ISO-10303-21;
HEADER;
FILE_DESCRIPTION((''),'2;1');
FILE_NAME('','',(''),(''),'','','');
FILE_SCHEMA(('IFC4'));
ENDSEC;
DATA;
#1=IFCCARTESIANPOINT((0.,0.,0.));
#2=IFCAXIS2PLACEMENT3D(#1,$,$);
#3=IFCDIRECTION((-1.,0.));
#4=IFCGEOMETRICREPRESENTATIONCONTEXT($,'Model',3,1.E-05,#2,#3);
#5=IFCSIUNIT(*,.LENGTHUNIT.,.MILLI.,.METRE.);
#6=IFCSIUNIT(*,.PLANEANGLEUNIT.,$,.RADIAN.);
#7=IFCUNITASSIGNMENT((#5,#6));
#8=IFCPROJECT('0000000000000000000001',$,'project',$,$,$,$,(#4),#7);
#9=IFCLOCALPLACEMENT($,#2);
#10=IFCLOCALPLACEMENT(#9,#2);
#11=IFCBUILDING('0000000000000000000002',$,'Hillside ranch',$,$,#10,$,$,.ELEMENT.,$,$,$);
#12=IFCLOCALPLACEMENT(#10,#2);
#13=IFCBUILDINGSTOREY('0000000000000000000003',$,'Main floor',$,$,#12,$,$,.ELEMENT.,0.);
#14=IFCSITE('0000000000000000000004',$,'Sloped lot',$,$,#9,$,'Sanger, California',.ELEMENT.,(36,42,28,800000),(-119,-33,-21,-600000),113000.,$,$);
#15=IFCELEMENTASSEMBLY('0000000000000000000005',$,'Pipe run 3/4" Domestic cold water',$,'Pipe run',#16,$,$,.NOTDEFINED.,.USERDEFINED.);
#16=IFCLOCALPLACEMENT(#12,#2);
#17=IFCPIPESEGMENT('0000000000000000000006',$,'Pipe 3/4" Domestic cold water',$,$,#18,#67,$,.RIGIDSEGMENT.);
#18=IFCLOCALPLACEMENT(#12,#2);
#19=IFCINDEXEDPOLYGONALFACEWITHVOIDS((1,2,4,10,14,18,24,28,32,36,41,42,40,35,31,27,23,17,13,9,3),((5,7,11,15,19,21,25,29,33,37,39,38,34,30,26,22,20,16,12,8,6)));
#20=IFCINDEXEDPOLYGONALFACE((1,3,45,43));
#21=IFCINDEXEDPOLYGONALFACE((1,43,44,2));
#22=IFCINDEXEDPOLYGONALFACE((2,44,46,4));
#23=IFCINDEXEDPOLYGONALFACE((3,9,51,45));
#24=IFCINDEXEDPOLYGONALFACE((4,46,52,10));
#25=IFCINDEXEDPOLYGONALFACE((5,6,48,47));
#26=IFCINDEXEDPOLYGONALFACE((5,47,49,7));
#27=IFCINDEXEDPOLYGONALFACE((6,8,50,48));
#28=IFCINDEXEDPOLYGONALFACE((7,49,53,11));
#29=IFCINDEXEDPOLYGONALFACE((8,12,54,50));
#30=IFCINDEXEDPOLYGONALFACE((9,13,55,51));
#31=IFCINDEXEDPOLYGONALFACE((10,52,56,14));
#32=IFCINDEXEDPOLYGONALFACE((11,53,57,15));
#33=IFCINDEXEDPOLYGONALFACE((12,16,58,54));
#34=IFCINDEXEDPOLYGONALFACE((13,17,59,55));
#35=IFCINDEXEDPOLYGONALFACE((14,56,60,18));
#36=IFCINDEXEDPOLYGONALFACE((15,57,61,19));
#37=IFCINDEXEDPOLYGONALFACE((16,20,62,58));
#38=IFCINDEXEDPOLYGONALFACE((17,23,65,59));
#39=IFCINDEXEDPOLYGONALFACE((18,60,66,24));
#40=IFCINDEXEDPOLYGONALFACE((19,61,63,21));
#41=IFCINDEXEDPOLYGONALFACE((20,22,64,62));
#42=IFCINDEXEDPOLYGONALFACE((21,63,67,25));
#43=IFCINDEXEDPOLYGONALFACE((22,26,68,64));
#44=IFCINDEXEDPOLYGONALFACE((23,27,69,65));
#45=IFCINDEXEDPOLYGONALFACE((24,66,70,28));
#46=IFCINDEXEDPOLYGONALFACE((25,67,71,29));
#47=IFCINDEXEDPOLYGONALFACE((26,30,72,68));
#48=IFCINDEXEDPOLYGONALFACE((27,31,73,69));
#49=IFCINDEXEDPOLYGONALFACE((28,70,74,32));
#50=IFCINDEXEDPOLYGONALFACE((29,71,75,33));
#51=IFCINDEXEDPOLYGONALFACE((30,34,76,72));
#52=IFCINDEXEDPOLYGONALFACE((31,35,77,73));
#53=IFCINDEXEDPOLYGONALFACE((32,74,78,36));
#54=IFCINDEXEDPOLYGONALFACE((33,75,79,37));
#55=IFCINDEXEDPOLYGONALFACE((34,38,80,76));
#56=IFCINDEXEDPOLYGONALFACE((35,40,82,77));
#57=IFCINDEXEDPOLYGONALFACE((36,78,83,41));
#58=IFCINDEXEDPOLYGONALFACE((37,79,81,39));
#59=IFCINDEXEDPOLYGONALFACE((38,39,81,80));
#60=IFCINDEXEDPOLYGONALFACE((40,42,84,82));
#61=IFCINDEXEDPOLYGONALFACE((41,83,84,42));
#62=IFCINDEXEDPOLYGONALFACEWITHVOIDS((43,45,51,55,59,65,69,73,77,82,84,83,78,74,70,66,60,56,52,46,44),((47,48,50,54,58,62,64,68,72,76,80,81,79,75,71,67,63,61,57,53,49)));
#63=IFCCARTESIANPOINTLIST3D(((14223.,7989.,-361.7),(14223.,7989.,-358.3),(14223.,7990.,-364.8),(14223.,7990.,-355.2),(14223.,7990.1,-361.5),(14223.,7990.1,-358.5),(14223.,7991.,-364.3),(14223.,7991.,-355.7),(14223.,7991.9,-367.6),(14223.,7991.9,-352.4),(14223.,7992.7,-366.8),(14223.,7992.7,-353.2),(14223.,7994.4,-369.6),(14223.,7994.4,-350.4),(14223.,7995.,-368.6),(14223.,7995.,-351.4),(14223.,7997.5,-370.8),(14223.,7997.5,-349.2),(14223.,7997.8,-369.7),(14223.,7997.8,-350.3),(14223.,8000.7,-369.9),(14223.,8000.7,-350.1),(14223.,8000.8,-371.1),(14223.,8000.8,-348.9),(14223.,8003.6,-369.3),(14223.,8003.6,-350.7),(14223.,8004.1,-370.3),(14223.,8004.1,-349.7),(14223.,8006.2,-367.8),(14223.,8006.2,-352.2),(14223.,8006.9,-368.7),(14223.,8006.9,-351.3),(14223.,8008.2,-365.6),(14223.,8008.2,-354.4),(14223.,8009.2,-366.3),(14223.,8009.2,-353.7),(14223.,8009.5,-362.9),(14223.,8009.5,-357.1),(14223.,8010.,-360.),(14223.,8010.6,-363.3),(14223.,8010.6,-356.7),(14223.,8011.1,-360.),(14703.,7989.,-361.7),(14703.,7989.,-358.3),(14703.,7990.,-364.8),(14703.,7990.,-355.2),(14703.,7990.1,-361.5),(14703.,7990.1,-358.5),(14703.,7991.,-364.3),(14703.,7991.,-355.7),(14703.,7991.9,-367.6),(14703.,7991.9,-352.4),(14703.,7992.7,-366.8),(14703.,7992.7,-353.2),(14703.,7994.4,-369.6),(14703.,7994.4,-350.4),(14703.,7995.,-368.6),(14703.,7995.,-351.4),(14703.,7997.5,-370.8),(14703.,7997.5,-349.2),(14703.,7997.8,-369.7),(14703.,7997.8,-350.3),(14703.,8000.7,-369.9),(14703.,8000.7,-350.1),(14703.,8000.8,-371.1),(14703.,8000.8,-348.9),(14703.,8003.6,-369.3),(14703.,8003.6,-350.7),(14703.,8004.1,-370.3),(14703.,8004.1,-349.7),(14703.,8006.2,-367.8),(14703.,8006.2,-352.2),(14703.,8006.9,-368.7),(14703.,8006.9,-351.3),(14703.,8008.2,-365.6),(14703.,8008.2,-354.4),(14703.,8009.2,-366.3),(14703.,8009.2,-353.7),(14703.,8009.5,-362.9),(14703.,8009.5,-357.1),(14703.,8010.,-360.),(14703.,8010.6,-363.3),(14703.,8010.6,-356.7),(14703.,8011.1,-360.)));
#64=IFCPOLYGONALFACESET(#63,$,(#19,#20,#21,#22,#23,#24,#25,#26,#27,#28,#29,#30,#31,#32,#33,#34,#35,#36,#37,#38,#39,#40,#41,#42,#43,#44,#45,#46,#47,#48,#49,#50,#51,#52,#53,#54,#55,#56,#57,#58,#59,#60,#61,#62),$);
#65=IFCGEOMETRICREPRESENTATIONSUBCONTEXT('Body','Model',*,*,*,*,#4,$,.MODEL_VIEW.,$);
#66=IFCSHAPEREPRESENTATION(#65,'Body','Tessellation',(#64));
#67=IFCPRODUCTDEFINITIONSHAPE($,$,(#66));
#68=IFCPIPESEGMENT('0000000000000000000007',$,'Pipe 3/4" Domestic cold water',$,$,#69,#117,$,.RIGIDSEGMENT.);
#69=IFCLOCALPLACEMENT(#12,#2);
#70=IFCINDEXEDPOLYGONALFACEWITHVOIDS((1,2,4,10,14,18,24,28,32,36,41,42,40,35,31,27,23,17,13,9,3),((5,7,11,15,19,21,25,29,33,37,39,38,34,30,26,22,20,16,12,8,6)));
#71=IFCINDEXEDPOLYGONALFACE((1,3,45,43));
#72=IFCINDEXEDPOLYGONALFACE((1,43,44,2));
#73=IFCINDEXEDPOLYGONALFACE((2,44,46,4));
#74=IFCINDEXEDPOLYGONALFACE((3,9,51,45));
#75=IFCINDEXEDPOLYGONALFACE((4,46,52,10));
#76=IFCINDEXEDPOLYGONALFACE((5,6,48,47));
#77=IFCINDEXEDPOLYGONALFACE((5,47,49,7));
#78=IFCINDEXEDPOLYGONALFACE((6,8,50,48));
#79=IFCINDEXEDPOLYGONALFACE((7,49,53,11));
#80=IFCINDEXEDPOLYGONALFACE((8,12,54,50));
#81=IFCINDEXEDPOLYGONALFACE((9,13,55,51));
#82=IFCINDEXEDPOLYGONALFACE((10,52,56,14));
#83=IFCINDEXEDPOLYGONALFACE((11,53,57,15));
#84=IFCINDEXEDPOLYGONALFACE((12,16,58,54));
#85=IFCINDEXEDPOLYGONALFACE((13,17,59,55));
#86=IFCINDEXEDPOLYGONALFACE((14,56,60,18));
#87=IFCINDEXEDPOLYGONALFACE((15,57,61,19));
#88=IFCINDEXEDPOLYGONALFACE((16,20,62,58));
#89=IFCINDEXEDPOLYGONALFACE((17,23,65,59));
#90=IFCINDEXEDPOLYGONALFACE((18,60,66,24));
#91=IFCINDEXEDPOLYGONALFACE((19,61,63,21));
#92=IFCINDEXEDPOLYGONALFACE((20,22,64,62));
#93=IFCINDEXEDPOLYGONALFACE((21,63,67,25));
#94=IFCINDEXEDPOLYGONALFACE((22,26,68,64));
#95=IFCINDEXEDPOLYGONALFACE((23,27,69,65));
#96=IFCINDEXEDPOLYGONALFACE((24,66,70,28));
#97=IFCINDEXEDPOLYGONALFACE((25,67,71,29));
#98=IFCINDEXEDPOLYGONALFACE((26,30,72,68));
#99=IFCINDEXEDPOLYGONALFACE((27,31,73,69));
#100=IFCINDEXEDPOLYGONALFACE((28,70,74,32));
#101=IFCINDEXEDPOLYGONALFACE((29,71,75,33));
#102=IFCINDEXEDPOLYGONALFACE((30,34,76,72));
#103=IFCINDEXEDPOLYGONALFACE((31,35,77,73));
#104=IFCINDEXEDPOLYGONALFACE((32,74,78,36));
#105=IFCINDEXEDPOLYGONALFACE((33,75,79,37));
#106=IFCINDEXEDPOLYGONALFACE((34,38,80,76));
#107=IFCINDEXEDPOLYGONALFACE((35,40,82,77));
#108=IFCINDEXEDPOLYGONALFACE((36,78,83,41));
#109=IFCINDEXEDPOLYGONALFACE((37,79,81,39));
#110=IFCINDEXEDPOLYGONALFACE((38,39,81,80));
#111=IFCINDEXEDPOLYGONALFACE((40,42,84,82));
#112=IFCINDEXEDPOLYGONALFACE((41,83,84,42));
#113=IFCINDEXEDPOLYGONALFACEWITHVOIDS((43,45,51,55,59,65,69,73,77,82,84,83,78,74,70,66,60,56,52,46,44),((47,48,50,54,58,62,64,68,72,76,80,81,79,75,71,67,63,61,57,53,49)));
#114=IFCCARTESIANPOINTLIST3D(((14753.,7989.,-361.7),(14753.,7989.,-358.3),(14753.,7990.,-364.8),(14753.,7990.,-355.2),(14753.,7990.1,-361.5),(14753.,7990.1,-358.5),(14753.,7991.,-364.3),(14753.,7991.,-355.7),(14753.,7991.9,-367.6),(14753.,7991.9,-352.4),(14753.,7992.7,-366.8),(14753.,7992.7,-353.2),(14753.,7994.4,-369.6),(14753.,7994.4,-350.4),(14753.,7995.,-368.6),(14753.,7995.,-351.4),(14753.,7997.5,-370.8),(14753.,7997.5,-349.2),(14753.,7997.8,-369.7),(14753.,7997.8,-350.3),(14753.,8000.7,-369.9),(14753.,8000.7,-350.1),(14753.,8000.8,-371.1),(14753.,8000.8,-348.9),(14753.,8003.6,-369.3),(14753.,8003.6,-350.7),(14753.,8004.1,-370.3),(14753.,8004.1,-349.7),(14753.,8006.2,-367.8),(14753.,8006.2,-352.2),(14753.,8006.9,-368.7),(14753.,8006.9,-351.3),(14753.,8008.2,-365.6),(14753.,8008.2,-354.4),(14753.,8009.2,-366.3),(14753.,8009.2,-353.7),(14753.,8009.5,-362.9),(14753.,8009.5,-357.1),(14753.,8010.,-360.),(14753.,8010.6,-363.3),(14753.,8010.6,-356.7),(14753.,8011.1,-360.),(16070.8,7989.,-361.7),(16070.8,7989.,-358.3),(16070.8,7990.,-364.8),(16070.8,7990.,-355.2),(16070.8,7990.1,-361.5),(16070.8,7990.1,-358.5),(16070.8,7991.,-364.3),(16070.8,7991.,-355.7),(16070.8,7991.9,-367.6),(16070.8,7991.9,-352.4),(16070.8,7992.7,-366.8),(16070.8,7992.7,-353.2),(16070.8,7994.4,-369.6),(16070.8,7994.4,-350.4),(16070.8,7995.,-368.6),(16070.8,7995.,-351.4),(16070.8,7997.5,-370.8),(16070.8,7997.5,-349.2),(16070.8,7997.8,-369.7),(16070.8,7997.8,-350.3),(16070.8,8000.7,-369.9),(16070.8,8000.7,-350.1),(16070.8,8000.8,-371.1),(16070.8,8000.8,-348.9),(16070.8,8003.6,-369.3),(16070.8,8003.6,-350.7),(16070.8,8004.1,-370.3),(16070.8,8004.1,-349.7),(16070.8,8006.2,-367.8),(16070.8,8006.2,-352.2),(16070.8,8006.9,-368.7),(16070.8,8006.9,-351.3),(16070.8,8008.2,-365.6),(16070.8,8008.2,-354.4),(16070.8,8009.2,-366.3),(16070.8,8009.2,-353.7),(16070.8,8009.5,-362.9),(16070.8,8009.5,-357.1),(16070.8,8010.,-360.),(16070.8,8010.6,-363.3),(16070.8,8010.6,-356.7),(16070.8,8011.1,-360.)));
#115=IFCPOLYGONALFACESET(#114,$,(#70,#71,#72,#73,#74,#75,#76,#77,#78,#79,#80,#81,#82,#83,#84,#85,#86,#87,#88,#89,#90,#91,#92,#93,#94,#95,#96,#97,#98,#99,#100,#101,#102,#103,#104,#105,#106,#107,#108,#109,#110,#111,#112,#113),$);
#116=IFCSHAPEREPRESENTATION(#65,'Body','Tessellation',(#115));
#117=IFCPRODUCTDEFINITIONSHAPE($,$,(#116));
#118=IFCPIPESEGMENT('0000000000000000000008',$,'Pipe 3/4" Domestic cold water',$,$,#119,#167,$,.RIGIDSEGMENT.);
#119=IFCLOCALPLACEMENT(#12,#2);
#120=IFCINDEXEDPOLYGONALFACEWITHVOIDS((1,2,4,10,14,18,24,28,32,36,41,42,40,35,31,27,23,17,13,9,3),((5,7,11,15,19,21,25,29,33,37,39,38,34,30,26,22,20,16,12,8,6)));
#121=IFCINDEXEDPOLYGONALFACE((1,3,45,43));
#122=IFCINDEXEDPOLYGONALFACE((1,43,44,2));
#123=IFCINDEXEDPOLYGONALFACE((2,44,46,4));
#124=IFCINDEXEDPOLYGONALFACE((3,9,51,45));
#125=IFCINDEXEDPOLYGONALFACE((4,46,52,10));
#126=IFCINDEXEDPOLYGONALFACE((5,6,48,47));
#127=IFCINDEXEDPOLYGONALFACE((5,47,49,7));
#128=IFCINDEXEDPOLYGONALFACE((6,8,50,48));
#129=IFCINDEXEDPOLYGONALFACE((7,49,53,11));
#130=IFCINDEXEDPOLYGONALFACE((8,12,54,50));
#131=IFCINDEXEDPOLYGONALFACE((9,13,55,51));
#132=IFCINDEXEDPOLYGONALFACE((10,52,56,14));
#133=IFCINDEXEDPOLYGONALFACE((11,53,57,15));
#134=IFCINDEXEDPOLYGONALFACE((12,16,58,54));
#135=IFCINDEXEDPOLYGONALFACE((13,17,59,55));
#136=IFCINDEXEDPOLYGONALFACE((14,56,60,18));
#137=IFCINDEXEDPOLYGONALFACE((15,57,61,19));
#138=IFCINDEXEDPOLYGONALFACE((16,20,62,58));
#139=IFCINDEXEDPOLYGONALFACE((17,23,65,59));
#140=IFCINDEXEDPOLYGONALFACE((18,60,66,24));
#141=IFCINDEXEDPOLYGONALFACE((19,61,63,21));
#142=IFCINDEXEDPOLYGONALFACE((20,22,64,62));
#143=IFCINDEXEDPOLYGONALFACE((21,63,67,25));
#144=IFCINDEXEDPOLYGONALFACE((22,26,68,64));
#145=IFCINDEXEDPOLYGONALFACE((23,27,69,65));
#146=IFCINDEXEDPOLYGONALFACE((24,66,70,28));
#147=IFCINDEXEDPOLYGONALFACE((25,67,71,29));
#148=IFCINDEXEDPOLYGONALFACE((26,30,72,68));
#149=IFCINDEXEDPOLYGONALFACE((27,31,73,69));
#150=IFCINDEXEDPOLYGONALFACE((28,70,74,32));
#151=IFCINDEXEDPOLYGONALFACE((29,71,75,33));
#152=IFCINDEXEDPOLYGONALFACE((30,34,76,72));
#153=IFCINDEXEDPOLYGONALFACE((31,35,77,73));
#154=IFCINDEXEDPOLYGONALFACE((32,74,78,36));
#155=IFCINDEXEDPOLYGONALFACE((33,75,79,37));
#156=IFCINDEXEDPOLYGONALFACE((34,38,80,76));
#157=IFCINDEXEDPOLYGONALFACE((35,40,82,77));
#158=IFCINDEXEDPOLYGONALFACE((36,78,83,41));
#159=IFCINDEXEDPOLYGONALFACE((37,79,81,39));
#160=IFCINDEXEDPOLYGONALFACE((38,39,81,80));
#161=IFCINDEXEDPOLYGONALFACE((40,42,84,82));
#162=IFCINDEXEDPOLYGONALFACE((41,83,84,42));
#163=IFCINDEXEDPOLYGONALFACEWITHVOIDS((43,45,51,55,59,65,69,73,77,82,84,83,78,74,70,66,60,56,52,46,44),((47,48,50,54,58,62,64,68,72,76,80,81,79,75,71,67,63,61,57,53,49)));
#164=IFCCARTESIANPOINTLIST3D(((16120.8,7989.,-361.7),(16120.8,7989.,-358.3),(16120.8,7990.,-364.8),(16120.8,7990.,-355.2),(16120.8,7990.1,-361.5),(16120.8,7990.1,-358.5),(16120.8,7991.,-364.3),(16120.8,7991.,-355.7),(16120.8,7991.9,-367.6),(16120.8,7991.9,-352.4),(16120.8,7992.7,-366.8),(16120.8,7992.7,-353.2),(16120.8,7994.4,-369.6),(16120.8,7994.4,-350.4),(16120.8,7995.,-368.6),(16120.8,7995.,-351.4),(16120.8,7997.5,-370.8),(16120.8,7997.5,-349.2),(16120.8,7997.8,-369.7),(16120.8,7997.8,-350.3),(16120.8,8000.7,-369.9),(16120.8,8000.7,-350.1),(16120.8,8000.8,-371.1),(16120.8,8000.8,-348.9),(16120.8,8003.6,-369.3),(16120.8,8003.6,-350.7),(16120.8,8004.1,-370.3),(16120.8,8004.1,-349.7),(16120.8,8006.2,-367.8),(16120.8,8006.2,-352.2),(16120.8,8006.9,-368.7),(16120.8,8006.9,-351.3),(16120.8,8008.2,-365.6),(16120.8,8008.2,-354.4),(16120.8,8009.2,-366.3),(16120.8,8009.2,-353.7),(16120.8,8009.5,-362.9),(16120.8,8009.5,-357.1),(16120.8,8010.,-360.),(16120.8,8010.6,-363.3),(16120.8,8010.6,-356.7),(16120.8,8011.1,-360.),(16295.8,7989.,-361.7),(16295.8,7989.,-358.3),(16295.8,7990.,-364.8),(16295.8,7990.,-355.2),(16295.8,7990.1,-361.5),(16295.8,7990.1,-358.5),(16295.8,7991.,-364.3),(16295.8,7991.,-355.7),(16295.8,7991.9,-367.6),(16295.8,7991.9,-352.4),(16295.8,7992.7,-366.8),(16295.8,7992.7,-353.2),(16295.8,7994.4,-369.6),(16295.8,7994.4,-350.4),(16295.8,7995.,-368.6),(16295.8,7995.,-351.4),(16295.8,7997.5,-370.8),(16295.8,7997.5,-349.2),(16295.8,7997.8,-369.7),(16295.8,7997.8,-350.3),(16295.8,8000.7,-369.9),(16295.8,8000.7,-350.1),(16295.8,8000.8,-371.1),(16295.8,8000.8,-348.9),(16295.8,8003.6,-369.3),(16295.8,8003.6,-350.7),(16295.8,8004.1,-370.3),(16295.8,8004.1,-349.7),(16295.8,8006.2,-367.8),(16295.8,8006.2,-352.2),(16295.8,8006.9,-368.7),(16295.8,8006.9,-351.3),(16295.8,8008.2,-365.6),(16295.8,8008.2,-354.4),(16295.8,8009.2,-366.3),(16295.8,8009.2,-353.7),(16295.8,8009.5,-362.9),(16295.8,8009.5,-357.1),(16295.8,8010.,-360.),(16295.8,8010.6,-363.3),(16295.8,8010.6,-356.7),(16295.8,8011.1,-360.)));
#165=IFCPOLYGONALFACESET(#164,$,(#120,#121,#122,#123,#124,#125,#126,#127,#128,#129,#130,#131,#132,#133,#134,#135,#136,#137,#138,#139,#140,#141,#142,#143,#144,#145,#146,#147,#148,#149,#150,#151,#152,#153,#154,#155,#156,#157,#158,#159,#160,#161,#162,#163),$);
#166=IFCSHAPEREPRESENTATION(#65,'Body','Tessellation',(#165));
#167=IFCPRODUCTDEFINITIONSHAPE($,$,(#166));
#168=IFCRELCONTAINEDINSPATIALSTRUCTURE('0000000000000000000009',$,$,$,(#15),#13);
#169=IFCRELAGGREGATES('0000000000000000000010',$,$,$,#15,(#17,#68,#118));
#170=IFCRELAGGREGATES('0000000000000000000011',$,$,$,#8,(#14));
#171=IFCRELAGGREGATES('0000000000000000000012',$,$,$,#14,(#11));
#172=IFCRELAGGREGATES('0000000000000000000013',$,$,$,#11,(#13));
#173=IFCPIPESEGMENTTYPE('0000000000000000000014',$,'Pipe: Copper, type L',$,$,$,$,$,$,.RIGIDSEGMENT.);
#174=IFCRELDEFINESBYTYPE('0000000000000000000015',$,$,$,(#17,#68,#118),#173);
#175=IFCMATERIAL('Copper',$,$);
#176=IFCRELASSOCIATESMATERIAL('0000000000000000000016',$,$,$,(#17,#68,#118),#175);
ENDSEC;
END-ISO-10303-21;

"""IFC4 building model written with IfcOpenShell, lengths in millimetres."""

from ifc_helpers import new_model, si_unit, direction, frame, origin, origin_with_axes, origin_2d, place, context, subcontext, project, spatial, hollow_circle, extrude, material, type_object, element, aggregate, save


model = new_model("IFC4")

# Units and contexts
model_context = context("Model", 3, precision=1e-05, world=origin(), true_north=direction((-1.0, 0.0)))
body_context = subcontext(model_context, "Body", "Model", "MODEL_VIEW")
ifc_project = project(units=[si_unit("LENGTHUNIT", "METRE", prefix="MILLI"), si_unit("PLANEANGLEUNIT", "RADIAN")], contexts=[model_context])

# Site, building, storey
site_placement = place(None, origin())
site = spatial("IfcSite", under=ifc_project, at=site_placement, Name="Sloped lot", LongName="Sanger, California", CompositionType="ELEMENT", RefLatitude=(36, 42, 28, 800000), RefLongitude=(-119, -33, -21, -600000), RefElevation=113000.0)
building_placement = place(site_placement, origin())
building = spatial("IfcBuilding", under=site, at=building_placement, Name="Hillside ranch", CompositionType="ELEMENT")
storey_placement = place(building_placement, origin())
storey = spatial("IfcBuildingStorey", under=building, at=storey_placement, Name="Main floor", CompositionType="ELEMENT", Elevation=0.0)

# Element assembly
assembly_1_placement = place(storey_placement, origin_with_axes())
assembly_1 = element("IfcElementAssembly", 1, at=assembly_1_placement, inside=storey, Name="Pipe run 3/4\" Domestic cold water", ObjectType="Pipe run", AssemblyPlace="NOTDEFINED", PredefinedType="USERDEFINED")
ifc_material = material(Name="Copper")

# Pipe segments
pipe_segment_type = type_object("IfcPipeSegmentType", Name="Pipe: Copper, type L", PredefinedType="RIGIDSEGMENT")
pipe_segment_1_placement = place(storey_placement, origin_with_axes())
pipe_segment_1 = element("IfcPipeSegment", 2, at=pipe_segment_1_placement, type_object=pipe_segment_type, material=ifc_material, Name="Pipe 3/4\" Domestic cold water", PredefinedType="RIGIDSEGMENT", context=body_context, shape_type="SweptSolid", body=[
    extrude(hollow_circle(Radius=11.1, WallThickness=1.1, at=origin_2d()), frame((14223.0, 8000.0, -360.0), z_axis=(1.0, 0.0, 0.0), x_axis=(0.0, 1.0, 0.0)), (0.0, 0.0, 1.0), 480.0),
])
pipe_segment_2_placement = place(storey_placement, origin_with_axes())
pipe_segment_2 = element("IfcPipeSegment", 3, at=pipe_segment_2_placement, type_object=pipe_segment_type, material=ifc_material, Name="Pipe 3/4\" Domestic cold water", PredefinedType="RIGIDSEGMENT", context=body_context, shape_type="SweptSolid", body=[
    extrude(hollow_circle(Radius=11.1, WallThickness=1.1, at=origin_2d()), frame((14753.0, 8000.0, -360.0), z_axis=(1.0, 0.0, 0.0), x_axis=(0.0, 1.0, 0.0)), (0.0, 0.0, 1.0), 1317.8),
])
pipe_segment_3_placement = place(storey_placement, origin_with_axes())
pipe_segment_3 = element("IfcPipeSegment", 4, at=pipe_segment_3_placement, type_object=pipe_segment_type, material=ifc_material, Name="Pipe 3/4\" Domestic cold water", PredefinedType="RIGIDSEGMENT", context=body_context, shape_type="SweptSolid", body=[
    extrude(hollow_circle(Radius=11.1, WallThickness=1.1, at=origin_2d()), frame((16120.8, 8000.0, -360.0), z_axis=(1.0, 0.0, 0.0), x_axis=(0.0, 1.0, 0.0)), (0.0, 0.0, 1.0), 175.0),
])
aggregate(assembly_1, [pipe_segment_1, pipe_segment_2, pipe_segment_3])

save(model, "model.ifc")
